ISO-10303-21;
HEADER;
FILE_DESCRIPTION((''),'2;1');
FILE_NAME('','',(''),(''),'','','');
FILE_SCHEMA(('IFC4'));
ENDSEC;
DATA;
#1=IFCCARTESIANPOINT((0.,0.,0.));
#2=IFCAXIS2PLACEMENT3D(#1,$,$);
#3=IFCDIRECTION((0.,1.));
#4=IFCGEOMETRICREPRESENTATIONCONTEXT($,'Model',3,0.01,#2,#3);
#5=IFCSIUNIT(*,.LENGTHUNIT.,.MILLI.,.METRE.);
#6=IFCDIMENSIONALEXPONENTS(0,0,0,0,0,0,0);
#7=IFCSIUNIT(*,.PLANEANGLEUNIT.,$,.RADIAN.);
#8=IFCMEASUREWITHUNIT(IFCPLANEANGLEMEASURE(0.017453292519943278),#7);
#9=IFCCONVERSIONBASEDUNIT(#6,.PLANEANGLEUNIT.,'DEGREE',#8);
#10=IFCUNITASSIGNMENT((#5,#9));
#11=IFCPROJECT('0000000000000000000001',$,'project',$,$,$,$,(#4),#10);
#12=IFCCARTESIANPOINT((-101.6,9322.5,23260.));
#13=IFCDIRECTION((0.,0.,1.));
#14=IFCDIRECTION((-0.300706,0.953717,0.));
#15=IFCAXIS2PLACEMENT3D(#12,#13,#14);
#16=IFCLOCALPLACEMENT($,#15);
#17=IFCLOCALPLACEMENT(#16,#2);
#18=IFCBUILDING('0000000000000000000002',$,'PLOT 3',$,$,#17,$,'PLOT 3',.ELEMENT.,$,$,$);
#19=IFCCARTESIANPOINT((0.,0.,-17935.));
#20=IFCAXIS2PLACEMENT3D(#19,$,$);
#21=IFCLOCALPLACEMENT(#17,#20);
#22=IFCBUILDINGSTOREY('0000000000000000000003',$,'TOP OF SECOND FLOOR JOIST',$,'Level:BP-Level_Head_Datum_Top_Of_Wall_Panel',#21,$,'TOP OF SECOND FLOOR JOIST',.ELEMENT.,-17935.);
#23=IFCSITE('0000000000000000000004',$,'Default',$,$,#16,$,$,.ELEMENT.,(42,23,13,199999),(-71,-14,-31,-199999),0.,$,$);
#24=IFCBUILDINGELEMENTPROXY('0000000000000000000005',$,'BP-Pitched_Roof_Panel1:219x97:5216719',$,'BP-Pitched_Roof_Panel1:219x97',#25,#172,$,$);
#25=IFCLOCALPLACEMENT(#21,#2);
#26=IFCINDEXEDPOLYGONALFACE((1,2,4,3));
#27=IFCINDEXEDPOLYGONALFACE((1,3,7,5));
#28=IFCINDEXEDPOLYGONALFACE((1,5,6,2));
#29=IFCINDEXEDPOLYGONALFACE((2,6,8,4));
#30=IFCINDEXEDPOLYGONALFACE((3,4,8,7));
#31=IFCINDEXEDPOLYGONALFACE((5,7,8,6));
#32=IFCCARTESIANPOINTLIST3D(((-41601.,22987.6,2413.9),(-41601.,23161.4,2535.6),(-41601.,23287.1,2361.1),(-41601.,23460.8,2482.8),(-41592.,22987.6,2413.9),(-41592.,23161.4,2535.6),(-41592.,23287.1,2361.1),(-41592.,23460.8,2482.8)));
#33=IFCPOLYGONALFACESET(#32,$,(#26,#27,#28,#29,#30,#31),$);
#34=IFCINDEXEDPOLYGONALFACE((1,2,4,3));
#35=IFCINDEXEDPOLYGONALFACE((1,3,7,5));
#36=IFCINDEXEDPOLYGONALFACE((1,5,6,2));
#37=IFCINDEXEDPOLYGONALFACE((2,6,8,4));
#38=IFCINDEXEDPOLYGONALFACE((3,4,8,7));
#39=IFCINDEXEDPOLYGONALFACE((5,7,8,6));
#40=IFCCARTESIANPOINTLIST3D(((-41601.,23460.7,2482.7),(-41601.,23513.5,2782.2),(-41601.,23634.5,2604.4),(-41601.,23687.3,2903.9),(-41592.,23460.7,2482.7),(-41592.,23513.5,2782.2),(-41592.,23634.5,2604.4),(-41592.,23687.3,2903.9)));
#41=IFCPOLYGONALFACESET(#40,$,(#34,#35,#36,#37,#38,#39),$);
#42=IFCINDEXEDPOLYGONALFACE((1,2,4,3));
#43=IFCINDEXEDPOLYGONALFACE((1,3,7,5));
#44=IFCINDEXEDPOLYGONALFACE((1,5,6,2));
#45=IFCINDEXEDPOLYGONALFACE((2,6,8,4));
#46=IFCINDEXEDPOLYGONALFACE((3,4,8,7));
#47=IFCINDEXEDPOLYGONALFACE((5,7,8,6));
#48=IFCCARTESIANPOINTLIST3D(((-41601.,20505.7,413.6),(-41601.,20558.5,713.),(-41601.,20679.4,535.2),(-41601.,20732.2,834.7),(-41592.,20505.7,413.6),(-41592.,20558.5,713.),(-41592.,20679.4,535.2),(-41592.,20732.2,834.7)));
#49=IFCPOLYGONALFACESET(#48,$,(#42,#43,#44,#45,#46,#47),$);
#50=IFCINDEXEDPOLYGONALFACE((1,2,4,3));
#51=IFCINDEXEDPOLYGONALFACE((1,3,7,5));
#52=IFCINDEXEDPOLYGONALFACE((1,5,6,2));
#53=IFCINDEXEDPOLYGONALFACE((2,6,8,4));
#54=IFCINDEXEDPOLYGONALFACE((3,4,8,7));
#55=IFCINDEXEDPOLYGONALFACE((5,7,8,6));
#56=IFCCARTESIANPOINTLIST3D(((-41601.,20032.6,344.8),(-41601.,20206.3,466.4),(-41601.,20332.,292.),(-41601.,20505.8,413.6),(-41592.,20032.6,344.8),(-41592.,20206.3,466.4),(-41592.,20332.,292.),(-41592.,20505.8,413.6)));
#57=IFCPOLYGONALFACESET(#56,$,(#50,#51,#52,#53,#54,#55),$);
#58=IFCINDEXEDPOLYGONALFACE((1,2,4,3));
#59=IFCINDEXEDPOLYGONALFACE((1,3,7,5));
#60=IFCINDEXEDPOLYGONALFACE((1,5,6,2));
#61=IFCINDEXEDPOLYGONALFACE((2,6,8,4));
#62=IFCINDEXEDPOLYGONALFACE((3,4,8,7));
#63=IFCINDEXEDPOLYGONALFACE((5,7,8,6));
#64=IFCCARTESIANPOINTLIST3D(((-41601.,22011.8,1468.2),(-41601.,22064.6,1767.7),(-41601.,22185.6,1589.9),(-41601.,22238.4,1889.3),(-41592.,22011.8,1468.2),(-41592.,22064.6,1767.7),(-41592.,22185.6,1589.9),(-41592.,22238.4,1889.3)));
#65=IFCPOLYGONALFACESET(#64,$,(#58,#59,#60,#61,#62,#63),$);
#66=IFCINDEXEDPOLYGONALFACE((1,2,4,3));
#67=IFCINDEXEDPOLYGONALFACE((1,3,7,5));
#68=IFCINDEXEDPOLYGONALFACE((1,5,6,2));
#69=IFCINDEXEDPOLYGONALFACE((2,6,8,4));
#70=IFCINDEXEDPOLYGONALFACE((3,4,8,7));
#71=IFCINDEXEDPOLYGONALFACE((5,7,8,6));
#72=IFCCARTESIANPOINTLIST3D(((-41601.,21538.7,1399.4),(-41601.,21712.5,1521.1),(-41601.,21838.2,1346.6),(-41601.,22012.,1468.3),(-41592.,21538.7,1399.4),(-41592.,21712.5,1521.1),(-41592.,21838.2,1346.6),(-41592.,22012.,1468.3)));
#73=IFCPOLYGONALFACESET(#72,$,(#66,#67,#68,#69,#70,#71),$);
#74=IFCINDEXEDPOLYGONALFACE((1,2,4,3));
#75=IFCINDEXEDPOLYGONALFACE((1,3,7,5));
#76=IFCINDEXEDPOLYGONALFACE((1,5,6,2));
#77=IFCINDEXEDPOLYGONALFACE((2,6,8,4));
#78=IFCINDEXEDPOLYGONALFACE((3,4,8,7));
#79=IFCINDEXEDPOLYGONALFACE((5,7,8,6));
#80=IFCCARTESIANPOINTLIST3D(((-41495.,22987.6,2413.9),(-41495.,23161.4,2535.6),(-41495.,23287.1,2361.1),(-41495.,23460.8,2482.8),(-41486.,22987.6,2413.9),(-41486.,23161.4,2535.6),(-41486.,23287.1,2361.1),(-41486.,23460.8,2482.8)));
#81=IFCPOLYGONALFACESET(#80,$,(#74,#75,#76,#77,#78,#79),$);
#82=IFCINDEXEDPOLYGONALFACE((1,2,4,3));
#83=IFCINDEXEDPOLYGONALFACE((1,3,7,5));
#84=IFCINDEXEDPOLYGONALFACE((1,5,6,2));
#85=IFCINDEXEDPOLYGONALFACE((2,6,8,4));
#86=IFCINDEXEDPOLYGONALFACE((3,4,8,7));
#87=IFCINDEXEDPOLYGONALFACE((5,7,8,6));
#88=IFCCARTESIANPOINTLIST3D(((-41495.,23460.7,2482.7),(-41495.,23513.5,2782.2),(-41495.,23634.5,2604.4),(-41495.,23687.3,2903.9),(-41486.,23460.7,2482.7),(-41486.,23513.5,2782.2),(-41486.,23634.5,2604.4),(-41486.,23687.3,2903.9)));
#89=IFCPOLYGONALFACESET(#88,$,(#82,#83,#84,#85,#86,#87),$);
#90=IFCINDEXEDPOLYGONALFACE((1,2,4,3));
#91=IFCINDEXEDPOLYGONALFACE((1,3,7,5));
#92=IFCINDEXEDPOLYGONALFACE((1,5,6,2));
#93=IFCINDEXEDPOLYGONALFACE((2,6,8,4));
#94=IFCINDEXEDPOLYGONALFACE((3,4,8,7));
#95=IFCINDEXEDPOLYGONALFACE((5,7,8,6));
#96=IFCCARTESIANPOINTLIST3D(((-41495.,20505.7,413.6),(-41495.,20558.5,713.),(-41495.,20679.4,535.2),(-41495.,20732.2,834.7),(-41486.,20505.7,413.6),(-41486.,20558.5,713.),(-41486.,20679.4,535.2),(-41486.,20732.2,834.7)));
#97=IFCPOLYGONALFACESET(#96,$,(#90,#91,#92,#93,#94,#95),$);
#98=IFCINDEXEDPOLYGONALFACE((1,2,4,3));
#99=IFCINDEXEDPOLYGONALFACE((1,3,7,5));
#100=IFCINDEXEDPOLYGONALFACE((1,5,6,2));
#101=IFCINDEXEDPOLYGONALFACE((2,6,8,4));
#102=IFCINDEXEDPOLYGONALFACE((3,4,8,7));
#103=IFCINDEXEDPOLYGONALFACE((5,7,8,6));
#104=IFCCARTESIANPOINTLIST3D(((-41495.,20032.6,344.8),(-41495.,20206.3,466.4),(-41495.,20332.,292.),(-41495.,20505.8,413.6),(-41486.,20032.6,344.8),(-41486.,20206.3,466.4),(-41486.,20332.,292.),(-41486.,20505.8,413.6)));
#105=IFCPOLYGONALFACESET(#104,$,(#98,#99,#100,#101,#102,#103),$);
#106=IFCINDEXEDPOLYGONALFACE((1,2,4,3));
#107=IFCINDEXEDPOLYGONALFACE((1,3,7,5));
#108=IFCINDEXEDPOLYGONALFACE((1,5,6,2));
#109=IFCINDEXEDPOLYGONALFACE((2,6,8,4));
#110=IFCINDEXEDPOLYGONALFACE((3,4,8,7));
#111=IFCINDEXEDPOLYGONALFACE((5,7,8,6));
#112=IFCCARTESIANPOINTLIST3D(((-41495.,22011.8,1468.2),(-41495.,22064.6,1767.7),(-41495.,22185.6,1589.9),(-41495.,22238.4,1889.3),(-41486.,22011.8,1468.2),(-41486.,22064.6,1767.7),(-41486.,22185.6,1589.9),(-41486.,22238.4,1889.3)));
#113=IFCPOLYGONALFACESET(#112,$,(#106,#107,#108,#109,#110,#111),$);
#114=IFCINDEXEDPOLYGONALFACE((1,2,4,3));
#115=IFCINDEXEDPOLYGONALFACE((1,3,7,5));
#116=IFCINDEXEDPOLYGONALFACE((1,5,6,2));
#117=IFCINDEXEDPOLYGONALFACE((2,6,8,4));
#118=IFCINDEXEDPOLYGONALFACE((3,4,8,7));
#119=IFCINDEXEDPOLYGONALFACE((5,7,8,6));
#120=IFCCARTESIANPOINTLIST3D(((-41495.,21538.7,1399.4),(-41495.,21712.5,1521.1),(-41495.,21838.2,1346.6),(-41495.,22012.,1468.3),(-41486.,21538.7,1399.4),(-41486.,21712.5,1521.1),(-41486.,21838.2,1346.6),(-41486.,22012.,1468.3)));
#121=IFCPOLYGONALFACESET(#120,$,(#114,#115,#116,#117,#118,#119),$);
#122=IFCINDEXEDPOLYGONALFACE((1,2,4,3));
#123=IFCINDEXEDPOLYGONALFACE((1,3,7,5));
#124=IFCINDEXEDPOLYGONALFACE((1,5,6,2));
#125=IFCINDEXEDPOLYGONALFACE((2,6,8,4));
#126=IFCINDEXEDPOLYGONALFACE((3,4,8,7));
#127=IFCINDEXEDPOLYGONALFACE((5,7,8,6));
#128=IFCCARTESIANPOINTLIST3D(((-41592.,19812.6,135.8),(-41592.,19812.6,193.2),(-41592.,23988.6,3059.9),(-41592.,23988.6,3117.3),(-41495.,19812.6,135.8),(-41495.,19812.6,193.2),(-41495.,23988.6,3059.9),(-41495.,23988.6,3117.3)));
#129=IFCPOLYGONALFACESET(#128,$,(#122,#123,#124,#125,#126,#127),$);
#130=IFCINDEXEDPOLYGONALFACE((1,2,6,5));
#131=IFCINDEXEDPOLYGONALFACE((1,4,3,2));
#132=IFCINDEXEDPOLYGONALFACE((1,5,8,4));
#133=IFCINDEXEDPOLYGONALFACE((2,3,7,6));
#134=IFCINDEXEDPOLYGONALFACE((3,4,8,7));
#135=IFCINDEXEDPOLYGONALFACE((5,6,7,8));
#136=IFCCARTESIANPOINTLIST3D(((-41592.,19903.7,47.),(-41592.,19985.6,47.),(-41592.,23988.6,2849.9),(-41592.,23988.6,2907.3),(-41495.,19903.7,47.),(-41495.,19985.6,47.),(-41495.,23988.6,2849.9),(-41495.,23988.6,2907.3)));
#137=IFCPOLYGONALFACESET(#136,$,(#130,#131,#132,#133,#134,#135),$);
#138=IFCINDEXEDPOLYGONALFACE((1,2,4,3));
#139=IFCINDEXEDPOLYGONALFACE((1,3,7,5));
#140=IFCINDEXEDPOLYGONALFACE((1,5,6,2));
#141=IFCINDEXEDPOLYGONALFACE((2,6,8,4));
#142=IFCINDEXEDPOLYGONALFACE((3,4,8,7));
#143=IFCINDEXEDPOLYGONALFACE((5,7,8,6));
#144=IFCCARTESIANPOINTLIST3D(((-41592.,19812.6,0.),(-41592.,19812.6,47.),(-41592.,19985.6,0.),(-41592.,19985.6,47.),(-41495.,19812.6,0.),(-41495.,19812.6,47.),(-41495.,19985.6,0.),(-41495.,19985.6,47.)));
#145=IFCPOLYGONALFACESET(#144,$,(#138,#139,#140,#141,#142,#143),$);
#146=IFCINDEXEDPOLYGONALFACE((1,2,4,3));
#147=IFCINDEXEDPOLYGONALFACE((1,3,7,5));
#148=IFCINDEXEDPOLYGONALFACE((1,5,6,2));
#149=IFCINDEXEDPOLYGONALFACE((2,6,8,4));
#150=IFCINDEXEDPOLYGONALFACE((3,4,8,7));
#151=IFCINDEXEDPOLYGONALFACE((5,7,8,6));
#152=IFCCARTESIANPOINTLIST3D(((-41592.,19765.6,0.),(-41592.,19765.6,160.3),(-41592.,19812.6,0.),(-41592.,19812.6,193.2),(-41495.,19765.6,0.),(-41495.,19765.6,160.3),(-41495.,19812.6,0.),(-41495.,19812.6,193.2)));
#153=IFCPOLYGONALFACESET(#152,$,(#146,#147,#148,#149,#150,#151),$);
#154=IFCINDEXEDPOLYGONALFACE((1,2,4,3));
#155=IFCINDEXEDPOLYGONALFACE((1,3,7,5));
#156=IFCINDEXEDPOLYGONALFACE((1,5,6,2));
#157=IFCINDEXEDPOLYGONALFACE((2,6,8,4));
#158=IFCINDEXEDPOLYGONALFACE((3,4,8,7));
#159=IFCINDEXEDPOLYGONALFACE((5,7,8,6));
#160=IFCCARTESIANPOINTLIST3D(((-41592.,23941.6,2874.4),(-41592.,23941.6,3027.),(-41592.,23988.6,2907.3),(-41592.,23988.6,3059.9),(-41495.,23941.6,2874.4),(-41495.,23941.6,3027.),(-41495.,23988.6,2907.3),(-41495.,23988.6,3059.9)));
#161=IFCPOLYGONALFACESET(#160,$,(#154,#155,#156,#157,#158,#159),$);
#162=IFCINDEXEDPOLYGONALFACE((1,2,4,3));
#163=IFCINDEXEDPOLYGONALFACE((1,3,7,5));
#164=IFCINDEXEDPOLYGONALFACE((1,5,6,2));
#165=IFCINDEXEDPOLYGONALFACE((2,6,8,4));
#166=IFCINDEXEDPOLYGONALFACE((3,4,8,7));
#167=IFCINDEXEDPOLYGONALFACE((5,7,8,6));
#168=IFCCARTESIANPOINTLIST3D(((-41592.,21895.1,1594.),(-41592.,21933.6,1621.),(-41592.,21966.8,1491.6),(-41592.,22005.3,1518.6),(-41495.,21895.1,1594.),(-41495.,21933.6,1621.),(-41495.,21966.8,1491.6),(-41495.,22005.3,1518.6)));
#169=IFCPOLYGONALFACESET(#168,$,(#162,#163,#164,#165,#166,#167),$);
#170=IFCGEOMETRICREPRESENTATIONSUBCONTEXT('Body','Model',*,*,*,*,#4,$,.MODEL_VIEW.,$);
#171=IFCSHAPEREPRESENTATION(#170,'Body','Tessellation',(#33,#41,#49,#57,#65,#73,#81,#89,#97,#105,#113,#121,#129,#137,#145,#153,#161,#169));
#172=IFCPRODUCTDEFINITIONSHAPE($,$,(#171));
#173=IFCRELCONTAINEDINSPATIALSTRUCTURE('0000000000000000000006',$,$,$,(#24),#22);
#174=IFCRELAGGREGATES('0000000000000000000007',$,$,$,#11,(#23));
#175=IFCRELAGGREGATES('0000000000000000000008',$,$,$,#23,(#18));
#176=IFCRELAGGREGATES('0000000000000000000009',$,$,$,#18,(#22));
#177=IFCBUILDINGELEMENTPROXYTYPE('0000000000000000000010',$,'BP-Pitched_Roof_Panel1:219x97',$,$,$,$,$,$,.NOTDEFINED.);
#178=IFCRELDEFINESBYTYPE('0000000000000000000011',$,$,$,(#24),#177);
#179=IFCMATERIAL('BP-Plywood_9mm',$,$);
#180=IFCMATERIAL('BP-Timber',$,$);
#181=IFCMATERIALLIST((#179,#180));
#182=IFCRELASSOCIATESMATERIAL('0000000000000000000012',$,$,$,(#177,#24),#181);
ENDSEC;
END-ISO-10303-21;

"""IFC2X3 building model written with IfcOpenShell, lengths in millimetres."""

from ifc_helpers import new_model, entity, si_unit, converted_unit, direction, frame, frame_2d, origin, origin_2d_with_axis, place, context, subcontext, project, spatial, polyline, rectangle, outline, extrude, source, transform, mapped, material, material_list, type_object, type_shapes, element, save


model = new_model("IFC2X3")

# Units and contexts
model_context = context("Model", 3, precision=0.01, world=origin(), true_north=direction((0.0, 1.0)))
body_context = subcontext(model_context, "Body", "Model", "MODEL_VIEW")
ifc_project = project(units=[si_unit("LENGTHUNIT", "METRE", prefix="MILLI"), converted_unit("PLANEANGLEUNIT", "DEGREE", entity("IfcPlaneAngleMeasure", 0.017453292519943278), si_unit("PLANEANGLEUNIT", "RADIAN"), dimensions=[0, 0, 0, 0, 0, 0, 0])], contexts=[model_context])

# Site, building, storey
site_placement = place(None, frame((-101.6, 9322.5, 23260.0), z_axis=(0.0, 0.0, 1.0), x_axis=(-0.300706, 0.953717, 0.0)))
site = spatial("IfcSite", under=ifc_project, at=site_placement, Name="Default", CompositionType="ELEMENT", RefLatitude=(42, 23, 13, 199999), RefLongitude=(-71, -14, -31, -199999), RefElevation=0.0)
building_placement = place(site_placement, origin())
building = spatial("IfcBuilding", under=site, at=building_placement, Name="PLOT 3", LongName="PLOT 3", CompositionType="ELEMENT")
storey_placement = place(building_placement, frame((0.0, 0.0, -17935.0)))
storey = spatial("IfcBuildingStorey", under=building, at=storey_placement, Name="TOP OF SECOND FLOOR JOIST", ObjectType="Level:BP-Level_Head_Datum_Top_Of_Wall_Panel", LongName="TOP OF SECOND FLOOR JOIST", CompositionType="ELEMENT", Elevation=-17935.0)

# Building element proxy
ifc_material_1 = material(Name="BP-Timber")
ifc_material_2 = material(Name="BP-Plywood_9mm")
ifc_material_list = material_list([ifc_material_2, ifc_material_1])
building_element_proxy_type_1 = type_object("IfcBuildingElementProxyType", Name="BP-Pitched_Roof_Panel1:219x97", PredefinedType="NOTDEFINED", material=ifc_material_list)
shared_shape_1 = source(origin(), body_context, "Body", "SweptSolid", [
    extrude(outline(polyline([(-77.0, -75.0), (227.0, -75.0), (77.0, 75.0), (-227.0, 75.0), (-77.0, -75.0)])), frame((36.3, 3947.0, 2448.4), z_axis=(0.0, 1.0, 0.0), x_axis=(-0.984808, 0.0, 0.173648)), (0.0, 0.0, 1.0), 9.0),
    extrude(outline(polyline([(1.4, -107.5), (213.6, -107.5), (-1.4, 107.5), (-213.6, 107.5), (1.4, -107.5)])), frame((386.1, 3947.0, 2693.3), z_axis=(0.0, 1.0, 0.0), x_axis=(-0.819152, 0.0, -0.573576)), (0.0, 0.0, 1.0), 9.0),
    extrude(outline(polyline([(1.4, -107.5), (213.6, -107.5), (-1.4, 107.5), (-213.6, 107.5), (1.4, -107.5)])), frame((-2569.0, 3947.0, 624.1), z_axis=(0.0, 1.0, 0.0), x_axis=(-0.819152, 0.0, -0.573576)), (0.0, 0.0, 1.0), 9.0),
    extrude(outline(polyline([(-77.0, -75.0), (227.0, -75.0), (77.0, 75.0), (-227.0, 75.0), (-77.0, -75.0)])), frame((-2918.8, 3947.0, 379.2), z_axis=(0.0, 1.0, 0.0), x_axis=(-0.984808, 0.0, 0.173648)), (0.0, 0.0, 1.0), 9.0),
    extrude(outline(polyline([(1.4, -107.5), (213.6, -107.5), (-1.4, 107.5), (-213.6, 107.5), (1.4, -107.5)])), frame((-1062.8, 3947.0, 1678.8), z_axis=(0.0, 1.0, 0.0), x_axis=(-0.819152, 0.0, -0.573576)), (0.0, 0.0, 1.0), 9.0),
    extrude(outline(polyline([(-77.0, -75.0), (227.0, -75.0), (77.0, 75.0), (-227.0, 75.0), (-77.0, -75.0)])), frame((-1412.6, 3947.0, 1433.9), z_axis=(0.0, 1.0, 0.0), x_axis=(-0.984808, 0.0, 0.173648)), (0.0, 0.0, 1.0), 9.0),
    extrude(outline(polyline([(-77.0, -75.0), (227.0, -75.0), (77.0, 75.0), (-227.0, 75.0), (-77.0, -75.0)])), frame((36.3, 3841.0, 2448.4), z_axis=(0.0, 1.0, 0.0), x_axis=(-0.984808, 0.0, 0.173648)), (0.0, 0.0, 1.0), 9.0),
    extrude(outline(polyline([(1.4, -107.5), (213.6, -107.5), (-1.4, 107.5), (-213.6, 107.5), (1.4, -107.5)])), frame((386.1, 3841.0, 2693.3), z_axis=(0.0, 1.0, 0.0), x_axis=(-0.819152, 0.0, -0.573576)), (0.0, 0.0, 1.0), 9.0),
    extrude(outline(polyline([(1.4, -107.5), (213.6, -107.5), (-1.4, 107.5), (-213.6, 107.5), (1.4, -107.5)])), frame((-2569.0, 3841.0, 624.1), z_axis=(0.0, 1.0, 0.0), x_axis=(-0.819152, 0.0, -0.573576)), (0.0, 0.0, 1.0), 9.0),
    extrude(outline(polyline([(-77.0, -75.0), (227.0, -75.0), (77.0, 75.0), (-227.0, 75.0), (-77.0, -75.0)])), frame((-2918.8, 3841.0, 379.2), z_axis=(0.0, 1.0, 0.0), x_axis=(-0.984808, 0.0, 0.173648)), (0.0, 0.0, 1.0), 9.0),
    extrude(outline(polyline([(1.4, -107.5), (213.6, -107.5), (-1.4, 107.5), (-213.6, 107.5), (1.4, -107.5)])), frame((-1062.8, 3841.0, 1678.8), z_axis=(0.0, 1.0, 0.0), x_axis=(-0.819152, 0.0, -0.573576)), (0.0, 0.0, 1.0), 9.0),
    extrude(outline(polyline([(-77.0, -75.0), (227.0, -75.0), (77.0, 75.0), (-227.0, 75.0), (-77.0, -75.0)])), frame((-1412.6, 3841.0, 1433.9), z_axis=(0.0, 1.0, 0.0), x_axis=(-0.984808, 0.0, 0.173648)), (0.0, 0.0, 1.0), 9.0),
    extrude(outline(polyline([(-1490.7, -2088.0), (-1433.3, -2088.0), (1490.7, 2088.0), (1433.3, 2088.0), (-1490.7, -2088.0)])), frame((-1287.3, 3850.0, 1626.6), z_axis=(0.0, 1.0, 0.0), x_axis=(0.0, 0.0, -1.0)), (0.0, 0.0, 1.0), 97.0),
    extrude(outline(polyline([(-1444.5, -2022.0), (-1387.1, -2022.0), (1415.8, 1981.0), (1415.8, 2063.0), (-1444.5, -2022.0)])), frame((-1221.3, 3850.0, 1462.8), z_axis=(0.0, 1.0, 0.0), x_axis=(0.0, 0.0, -1.0)), (0.0, 0.0, 1.0), 97.0),
    extrude(rectangle(XDim=97.0, YDim=173.0, at=origin_2d_with_axis()), frame((-3288.8, 3898.5, 0.0), z_axis=(0.0, 0.0, 1.0), x_axis=(0.0, 1.0, 0.0)), (0.0, 0.0, 1.0), 47.0),
    extrude(outline(polyline([(22.0, -72.4), (79.4, -72.4), (-31.4, 85.9), (-69.9, 58.9), (22.0, -72.4)])), frame((-3398.8, 3850.0, 88.4), z_axis=(0.0, 1.0, 0.0), x_axis=(0.819152, 0.0, 0.573576)), (0.0, 0.0, 1.0), 97.0),
    extrude(outline(polyline([(15.1, -62.5), (72.5, -62.5), (-15.1, 62.5), (-72.5, 62.5), (15.1, -62.5)])), frame((777.2, 3850.0, 2967.2), z_axis=(0.0, 1.0, 0.0), x_axis=(0.819152, 0.0, 0.573576)), (0.0, 0.0, 1.0), 97.0),
    extrude(rectangle(XDim=47.0, YDim=97.0, at=frame_2d((0.0, 0.0), x_axis=(0.0, 1.0))), frame((-1201.9, 3898.5, 1505.1), z_axis=(-0.573576, 0.0, 0.819152), x_axis=(0.0, 1.0, 0.0)), (0.0, 0.0, 1.0), 125.0),
])
type_shapes(building_element_proxy_type_1, [shared_shape_1])
for number, where, z_axis, x_axis, name in (
    (1, (-37645.0, 23187.9, 0.0), (0.0, 0.0, 1.0), (0.0, 1.0, 0.0), "BP-Pitched_Roof_Panel1:219x97:5216719"),
):
    element("IfcBuildingElementProxy", number, at=place(storey_placement, frame(where, z_axis=z_axis, x_axis=x_axis)), inside=storey, type_object=building_element_proxy_type_1, material=ifc_material_list, Name=name, ObjectType="BP-Pitched_Roof_Panel1:219x97", context=body_context, shape_type="MappedRepresentation", body=[
        mapped(shared_shape_1, transform((0.0, 0.0, 0.0), scale=1.0)),
    ])

save(model, "model.ifc")
